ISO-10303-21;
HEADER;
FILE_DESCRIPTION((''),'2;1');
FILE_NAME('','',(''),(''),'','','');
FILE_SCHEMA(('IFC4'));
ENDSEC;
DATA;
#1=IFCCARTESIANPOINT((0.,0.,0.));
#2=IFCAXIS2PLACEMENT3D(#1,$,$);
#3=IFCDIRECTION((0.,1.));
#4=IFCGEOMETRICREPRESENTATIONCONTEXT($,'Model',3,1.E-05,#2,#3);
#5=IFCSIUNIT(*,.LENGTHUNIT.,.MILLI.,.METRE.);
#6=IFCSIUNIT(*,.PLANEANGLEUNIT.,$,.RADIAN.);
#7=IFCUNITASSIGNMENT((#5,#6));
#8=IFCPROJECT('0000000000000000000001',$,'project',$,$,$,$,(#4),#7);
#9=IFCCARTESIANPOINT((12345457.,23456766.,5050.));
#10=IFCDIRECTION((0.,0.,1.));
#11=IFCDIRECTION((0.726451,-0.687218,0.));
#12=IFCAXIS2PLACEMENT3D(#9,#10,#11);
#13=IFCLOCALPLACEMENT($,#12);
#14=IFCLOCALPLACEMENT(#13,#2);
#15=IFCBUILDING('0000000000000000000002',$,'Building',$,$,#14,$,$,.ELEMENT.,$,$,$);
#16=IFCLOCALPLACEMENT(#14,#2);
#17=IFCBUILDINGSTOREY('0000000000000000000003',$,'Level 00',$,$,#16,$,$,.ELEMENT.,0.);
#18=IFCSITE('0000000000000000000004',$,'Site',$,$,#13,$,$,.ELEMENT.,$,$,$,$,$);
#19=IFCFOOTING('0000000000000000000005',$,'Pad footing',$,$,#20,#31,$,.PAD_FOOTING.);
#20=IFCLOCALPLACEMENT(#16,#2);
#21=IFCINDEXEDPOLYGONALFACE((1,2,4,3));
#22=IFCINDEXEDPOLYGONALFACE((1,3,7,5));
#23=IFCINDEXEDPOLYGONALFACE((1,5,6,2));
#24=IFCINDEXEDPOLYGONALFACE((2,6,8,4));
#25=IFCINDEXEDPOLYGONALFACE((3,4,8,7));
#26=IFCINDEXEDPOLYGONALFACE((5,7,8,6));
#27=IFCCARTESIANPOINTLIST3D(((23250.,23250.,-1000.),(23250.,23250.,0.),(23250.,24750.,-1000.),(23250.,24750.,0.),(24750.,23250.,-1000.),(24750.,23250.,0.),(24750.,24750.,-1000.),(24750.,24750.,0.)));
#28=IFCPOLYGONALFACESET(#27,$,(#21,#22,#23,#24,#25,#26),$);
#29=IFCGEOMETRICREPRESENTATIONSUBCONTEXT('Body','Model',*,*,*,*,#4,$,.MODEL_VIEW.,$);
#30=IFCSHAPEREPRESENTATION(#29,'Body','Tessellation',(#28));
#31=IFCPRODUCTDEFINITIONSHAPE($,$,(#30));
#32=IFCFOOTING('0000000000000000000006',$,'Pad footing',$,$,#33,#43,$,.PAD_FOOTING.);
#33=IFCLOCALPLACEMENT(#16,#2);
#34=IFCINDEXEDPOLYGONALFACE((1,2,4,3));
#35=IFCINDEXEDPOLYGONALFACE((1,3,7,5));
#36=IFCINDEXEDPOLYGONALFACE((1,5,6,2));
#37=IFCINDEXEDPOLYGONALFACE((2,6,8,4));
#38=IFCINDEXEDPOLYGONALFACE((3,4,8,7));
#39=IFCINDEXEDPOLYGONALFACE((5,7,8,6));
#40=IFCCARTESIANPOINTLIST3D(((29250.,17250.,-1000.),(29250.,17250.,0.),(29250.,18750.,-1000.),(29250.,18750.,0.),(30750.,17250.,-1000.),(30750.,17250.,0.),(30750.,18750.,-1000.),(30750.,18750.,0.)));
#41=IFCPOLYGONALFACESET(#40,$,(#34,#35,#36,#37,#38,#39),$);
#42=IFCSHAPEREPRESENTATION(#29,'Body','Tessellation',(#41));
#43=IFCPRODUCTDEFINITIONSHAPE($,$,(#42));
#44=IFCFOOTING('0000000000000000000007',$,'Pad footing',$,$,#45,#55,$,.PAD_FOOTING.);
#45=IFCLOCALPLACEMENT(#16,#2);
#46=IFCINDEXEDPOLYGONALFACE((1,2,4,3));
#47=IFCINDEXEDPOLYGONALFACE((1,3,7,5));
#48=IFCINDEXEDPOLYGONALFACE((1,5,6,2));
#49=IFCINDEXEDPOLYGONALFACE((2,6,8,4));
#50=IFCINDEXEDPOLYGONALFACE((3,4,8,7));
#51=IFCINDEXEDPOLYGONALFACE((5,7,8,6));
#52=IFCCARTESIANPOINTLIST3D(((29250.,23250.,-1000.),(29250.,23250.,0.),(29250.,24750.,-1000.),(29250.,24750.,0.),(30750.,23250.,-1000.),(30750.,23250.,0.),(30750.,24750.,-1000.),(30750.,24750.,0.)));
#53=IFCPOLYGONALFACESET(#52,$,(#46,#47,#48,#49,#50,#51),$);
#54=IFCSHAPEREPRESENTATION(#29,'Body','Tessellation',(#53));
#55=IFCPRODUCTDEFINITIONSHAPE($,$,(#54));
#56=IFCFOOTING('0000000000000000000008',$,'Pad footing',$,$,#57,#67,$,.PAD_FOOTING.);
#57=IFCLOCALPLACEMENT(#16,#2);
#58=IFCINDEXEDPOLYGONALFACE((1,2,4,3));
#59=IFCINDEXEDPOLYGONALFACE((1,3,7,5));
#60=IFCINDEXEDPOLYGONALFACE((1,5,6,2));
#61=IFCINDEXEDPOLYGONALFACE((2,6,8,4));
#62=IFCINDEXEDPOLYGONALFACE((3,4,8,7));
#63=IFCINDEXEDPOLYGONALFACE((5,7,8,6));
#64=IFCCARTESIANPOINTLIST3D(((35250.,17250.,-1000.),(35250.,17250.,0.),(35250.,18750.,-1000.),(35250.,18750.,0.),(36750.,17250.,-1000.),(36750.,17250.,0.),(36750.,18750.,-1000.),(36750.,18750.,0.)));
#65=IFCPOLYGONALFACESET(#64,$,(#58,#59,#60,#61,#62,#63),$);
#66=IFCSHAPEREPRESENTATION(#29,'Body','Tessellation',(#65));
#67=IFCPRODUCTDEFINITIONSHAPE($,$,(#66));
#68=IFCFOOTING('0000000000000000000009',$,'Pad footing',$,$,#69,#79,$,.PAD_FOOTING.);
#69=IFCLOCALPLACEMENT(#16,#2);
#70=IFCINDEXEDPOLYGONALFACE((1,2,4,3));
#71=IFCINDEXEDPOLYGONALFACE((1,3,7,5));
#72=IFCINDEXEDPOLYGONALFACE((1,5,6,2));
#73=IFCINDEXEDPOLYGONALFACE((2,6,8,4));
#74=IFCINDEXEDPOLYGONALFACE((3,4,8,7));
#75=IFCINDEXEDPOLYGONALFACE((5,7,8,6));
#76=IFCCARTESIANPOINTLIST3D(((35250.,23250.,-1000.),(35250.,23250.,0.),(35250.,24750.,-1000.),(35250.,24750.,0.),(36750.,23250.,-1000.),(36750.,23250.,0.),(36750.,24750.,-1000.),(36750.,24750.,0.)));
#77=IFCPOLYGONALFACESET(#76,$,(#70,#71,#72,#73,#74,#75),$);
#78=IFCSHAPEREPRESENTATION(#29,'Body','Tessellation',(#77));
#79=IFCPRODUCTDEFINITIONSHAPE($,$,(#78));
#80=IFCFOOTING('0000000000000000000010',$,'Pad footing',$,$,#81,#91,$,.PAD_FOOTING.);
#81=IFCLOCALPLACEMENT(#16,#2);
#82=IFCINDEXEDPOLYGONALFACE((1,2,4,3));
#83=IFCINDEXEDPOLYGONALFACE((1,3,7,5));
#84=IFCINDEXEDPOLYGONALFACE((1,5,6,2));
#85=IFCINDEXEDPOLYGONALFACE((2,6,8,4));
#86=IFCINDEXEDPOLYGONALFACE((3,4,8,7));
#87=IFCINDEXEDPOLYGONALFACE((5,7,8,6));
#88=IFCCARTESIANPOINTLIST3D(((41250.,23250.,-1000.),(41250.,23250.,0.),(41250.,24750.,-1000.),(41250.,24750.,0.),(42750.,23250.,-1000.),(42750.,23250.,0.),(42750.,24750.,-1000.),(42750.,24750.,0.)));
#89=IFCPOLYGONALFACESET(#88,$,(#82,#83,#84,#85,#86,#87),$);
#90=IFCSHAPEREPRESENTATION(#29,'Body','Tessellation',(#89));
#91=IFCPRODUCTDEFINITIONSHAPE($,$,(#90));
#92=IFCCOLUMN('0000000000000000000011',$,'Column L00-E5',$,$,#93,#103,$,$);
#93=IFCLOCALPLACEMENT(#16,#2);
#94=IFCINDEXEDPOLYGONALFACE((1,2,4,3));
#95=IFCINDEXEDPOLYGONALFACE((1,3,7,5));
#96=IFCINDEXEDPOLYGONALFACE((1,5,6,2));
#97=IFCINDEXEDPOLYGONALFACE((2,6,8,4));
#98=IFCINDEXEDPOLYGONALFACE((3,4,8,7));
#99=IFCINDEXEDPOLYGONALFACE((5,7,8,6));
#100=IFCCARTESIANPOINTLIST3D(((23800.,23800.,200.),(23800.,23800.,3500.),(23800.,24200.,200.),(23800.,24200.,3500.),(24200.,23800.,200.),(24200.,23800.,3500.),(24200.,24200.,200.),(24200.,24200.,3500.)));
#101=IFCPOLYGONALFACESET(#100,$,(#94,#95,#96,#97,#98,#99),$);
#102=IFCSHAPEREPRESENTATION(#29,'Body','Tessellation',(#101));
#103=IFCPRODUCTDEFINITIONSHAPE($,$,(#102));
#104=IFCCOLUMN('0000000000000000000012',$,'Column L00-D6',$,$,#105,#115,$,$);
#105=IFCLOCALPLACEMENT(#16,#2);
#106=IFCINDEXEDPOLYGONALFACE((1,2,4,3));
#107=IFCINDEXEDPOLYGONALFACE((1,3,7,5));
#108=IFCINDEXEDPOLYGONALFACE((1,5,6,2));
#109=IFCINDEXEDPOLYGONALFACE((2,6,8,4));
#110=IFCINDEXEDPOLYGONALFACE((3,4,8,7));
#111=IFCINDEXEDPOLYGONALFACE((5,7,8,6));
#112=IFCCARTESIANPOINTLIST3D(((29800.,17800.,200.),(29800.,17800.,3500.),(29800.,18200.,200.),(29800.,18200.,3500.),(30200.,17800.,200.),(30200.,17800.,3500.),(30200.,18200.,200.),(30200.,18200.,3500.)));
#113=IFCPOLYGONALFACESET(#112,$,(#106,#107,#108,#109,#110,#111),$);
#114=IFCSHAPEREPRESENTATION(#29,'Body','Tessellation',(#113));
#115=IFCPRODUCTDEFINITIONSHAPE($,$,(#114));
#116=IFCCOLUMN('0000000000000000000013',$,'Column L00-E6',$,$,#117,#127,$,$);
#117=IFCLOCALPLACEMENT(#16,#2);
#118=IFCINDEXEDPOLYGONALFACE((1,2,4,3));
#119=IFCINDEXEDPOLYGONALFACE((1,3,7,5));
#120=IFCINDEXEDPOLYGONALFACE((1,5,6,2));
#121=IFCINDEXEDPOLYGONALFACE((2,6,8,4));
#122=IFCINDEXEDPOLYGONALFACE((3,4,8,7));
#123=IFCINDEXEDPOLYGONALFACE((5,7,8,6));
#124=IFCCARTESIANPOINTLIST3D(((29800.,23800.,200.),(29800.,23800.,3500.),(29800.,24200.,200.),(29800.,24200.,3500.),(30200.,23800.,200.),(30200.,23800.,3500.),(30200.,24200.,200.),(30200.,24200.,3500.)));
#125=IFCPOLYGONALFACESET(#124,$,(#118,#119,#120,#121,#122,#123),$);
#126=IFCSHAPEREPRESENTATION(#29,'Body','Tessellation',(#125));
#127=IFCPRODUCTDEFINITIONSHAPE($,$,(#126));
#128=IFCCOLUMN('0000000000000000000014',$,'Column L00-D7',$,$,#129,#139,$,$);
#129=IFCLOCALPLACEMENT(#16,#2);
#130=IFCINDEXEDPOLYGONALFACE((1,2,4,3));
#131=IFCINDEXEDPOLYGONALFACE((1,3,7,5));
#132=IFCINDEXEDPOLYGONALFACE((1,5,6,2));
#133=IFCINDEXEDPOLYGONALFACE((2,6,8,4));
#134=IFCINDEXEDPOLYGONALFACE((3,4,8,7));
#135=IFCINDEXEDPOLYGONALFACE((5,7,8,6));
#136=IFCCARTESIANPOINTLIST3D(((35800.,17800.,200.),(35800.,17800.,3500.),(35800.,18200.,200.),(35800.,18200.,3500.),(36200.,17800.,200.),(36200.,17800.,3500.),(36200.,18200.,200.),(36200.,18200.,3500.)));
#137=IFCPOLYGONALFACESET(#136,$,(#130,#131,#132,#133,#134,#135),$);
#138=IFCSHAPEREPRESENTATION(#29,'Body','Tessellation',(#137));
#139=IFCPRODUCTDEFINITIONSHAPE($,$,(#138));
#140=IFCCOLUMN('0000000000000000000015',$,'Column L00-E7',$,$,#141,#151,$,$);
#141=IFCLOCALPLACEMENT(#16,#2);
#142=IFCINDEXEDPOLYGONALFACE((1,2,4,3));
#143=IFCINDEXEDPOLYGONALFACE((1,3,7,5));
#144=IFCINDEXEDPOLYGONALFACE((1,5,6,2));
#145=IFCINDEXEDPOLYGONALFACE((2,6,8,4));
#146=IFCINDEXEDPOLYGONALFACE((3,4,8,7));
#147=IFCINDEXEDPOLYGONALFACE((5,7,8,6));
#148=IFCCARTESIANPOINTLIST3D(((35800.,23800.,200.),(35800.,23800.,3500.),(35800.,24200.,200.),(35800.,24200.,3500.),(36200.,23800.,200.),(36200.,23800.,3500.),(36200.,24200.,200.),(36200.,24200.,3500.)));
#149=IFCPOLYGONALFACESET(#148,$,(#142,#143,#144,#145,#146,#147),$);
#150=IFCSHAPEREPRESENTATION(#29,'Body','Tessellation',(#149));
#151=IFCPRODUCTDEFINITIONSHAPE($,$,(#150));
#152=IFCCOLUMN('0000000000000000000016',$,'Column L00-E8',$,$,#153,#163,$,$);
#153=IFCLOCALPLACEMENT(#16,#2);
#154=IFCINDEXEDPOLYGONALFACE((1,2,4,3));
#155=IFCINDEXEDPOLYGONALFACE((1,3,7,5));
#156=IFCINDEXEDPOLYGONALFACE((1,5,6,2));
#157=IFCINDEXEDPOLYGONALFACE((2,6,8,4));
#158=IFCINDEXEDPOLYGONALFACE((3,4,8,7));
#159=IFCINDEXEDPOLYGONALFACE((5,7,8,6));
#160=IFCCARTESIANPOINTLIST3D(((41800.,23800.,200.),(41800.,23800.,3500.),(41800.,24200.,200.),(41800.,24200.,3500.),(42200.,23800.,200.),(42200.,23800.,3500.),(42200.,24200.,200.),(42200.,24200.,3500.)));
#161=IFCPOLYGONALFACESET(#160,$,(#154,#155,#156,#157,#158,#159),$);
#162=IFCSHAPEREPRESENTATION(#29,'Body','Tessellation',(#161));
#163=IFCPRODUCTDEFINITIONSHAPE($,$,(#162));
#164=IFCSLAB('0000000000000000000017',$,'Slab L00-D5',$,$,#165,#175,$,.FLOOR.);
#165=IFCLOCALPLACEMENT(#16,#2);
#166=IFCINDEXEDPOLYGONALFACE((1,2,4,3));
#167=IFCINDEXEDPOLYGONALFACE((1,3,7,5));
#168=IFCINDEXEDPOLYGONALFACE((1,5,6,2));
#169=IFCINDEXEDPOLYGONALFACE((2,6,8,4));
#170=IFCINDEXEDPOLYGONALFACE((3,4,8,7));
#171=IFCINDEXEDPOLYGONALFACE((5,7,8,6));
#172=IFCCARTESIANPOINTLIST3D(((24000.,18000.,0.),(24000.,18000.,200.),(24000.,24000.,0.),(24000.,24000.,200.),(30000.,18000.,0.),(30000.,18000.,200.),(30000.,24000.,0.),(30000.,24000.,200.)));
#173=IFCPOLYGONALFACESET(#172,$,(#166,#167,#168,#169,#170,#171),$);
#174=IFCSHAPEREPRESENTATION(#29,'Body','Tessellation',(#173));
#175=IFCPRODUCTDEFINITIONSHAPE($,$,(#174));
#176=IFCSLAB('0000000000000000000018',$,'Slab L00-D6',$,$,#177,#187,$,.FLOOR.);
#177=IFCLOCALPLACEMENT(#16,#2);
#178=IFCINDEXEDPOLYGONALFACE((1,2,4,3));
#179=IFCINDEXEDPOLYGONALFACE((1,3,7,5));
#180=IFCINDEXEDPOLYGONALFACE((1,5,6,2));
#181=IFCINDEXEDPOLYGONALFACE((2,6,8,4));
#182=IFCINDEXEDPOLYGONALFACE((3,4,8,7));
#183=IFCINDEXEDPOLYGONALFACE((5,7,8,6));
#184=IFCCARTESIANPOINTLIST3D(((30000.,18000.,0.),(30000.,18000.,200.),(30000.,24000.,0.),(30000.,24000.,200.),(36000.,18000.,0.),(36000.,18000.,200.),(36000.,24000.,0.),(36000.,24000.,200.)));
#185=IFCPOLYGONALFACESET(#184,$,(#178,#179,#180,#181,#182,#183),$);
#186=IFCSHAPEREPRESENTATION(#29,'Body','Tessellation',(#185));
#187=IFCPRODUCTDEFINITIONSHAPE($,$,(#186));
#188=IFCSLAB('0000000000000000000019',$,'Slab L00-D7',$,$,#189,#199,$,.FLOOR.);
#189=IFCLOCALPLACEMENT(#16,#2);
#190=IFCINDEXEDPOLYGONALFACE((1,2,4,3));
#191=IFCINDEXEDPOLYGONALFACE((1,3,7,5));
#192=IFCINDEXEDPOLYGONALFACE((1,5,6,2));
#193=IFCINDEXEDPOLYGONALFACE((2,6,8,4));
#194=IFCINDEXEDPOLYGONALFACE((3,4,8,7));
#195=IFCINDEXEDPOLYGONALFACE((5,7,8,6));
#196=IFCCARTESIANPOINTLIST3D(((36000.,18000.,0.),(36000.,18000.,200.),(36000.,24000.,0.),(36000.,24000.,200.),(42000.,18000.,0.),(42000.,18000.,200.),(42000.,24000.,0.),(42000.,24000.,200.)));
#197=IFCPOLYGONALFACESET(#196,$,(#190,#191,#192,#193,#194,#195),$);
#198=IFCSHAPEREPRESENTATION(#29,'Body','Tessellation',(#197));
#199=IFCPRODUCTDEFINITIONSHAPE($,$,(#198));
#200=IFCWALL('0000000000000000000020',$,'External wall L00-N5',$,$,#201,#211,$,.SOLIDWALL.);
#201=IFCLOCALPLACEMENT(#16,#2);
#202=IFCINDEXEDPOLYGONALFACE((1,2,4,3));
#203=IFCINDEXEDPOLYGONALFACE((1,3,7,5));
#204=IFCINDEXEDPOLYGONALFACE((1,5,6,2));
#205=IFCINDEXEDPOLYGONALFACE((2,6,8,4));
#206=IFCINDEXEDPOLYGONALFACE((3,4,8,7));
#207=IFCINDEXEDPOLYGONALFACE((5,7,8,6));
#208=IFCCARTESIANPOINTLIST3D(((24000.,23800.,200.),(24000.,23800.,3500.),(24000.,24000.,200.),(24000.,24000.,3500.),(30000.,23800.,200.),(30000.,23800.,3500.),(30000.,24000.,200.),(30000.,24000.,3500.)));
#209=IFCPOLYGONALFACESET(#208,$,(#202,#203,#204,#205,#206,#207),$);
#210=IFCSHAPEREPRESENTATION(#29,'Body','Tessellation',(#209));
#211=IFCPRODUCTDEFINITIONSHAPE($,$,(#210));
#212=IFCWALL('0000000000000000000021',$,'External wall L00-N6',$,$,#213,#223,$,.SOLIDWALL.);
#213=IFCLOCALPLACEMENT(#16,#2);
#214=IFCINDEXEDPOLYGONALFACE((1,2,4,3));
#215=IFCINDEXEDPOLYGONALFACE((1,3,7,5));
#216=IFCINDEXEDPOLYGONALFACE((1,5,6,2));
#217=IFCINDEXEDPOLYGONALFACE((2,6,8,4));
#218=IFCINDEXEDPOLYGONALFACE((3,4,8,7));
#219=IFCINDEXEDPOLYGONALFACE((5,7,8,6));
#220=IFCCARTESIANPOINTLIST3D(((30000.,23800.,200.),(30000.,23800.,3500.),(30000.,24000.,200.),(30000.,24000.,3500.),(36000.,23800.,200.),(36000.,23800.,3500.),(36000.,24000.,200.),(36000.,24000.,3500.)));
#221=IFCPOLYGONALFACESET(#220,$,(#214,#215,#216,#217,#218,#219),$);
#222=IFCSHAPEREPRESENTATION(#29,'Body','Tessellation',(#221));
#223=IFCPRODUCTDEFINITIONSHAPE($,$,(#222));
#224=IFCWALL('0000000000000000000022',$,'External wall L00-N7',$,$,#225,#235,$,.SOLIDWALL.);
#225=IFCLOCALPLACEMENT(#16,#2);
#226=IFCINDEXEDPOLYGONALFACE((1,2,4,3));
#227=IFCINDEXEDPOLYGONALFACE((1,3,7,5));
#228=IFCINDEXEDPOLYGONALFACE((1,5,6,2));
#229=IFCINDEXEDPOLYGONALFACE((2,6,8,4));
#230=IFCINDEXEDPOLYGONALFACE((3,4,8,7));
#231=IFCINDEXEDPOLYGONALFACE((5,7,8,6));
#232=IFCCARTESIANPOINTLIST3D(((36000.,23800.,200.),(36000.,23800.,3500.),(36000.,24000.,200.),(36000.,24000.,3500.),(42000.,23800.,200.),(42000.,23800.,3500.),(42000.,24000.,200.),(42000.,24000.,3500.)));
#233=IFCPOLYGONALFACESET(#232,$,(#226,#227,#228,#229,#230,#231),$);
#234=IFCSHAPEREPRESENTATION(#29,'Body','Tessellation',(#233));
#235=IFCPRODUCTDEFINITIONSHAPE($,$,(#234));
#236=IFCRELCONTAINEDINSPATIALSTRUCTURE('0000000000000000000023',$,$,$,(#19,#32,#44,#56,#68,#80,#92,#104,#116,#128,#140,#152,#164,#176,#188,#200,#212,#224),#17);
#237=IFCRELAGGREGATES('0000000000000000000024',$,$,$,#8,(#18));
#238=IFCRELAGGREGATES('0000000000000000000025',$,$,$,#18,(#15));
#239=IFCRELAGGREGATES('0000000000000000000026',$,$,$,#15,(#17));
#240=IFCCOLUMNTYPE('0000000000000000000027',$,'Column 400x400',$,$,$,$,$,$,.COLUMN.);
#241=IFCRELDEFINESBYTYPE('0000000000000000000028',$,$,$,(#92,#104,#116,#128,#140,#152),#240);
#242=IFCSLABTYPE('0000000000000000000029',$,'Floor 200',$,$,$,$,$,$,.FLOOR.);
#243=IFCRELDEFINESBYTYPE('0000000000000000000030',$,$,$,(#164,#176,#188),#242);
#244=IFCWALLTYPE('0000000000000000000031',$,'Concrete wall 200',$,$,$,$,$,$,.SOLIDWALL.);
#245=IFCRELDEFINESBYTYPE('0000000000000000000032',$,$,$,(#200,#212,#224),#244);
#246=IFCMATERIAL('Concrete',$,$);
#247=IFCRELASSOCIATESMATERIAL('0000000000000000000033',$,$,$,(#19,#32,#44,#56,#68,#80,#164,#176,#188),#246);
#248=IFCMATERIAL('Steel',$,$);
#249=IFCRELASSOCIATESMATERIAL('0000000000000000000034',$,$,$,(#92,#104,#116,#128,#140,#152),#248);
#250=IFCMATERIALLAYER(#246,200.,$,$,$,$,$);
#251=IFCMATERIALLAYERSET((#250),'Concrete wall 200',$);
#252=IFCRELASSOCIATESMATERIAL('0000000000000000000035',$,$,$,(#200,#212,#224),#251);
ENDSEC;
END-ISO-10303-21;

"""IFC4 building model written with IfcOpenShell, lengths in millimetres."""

from ifc_helpers import new_model, si_unit, direction, frame, origin, place, context, subcontext, project, spatial, rectangle, extrude, material, layer, layer_set, layer_usage, type_object, element, save


model = new_model("IFC4")

# Units and contexts
model_context = context("Model", 3, precision=1e-05, world=origin(), true_north=direction((0.0, 1.0)))
body_context = subcontext(model_context, "Body", "Model", "MODEL_VIEW")
ifc_project = project(units=[si_unit("LENGTHUNIT", "METRE", prefix="MILLI"), si_unit("PLANEANGLEUNIT", "RADIAN")], contexts=[model_context])

# Site, building, storey
site_placement = place(None, frame((12345457.0, 23456766.0, 5050.0), z_axis=(0.0, 0.0, 1.0), x_axis=(0.726451, -0.687218, 0.0)))
site = spatial("IfcSite", under=ifc_project, at=site_placement, Name="Site", CompositionType="ELEMENT")
building_placement = place(site_placement, origin())
building = spatial("IfcBuilding", under=site, at=building_placement, Name="Building", CompositionType="ELEMENT")
storey_placement = place(building_placement, origin())
storey = spatial("IfcBuildingStorey", under=building, at=storey_placement, Name="Level 00", CompositionType="ELEMENT", Elevation=0.0)

# Footings
ifc_material_1 = material(Name="Concrete")
for number, where, name in (
    (1, (23250.0, 23250.0, -1000.0), "Pad footing"),
    (2, (29250.0, 17250.0, -1000.0), "Pad footing"),
    (3, (29250.0, 23250.0, -1000.0), "Pad footing"),
    (4, (35250.0, 17250.0, -1000.0), "Pad footing"),
    (5, (35250.0, 23250.0, -1000.0), "Pad footing"),
    (6, (41250.0, 23250.0, -1000.0), "Pad footing"),
):
    element("IfcFooting", number, at=place(storey_placement, frame(where)), inside=storey, material=ifc_material_1, Name=name, PredefinedType="PAD_FOOTING", context=body_context, shape_type="SweptSolid", body=[
        extrude(rectangle(XDim=1500.0, YDim=1500.0), frame((750.0, 750.0, 0.0)), (0.0, 0.0, 1.0), 1000.0),
    ])

# Columns
ifc_material_2 = material(Name="Steel")
column_type = type_object("IfcColumnType", Name="Column 400x400", PredefinedType="COLUMN")
for number, where, name in (
    (7, (23800.0, 23800.0, 200.0), "Column L00-E5"),
    (8, (29800.0, 17800.0, 200.0), "Column L00-D6"),
    (9, (29800.0, 23800.0, 200.0), "Column L00-E6"),
    (10, (35800.0, 17800.0, 200.0), "Column L00-D7"),
    (11, (35800.0, 23800.0, 200.0), "Column L00-E7"),
    (12, (41800.0, 23800.0, 200.0), "Column L00-E8"),
):
    element("IfcColumn", number, at=place(storey_placement, frame(where)), inside=storey, type_object=column_type, material=ifc_material_2, Name=name, context=body_context, shape_type="SweptSolid", body=[
        extrude(rectangle(XDim=400.0, YDim=400.0), frame((200.0, 200.0, 0.0)), (0.0, 0.0, 1.0), 3300.0),
    ])

# Slabs
slab_type = type_object("IfcSlabType", Name="Floor 200", PredefinedType="FLOOR")
for number, where, name in (
    (13, (24000.0, 18000.0, 0.0), "Slab L00-D5"),
    (14, (30000.0, 18000.0, 0.0), "Slab L00-D6"),
    (15, (36000.0, 18000.0, 0.0), "Slab L00-D7"),
):
    element("IfcSlab", number, at=place(storey_placement, frame(where)), inside=storey, type_object=slab_type, material=ifc_material_1, Name=name, PredefinedType="FLOOR", context=body_context, shape_type="SweptSolid", body=[
        extrude(rectangle(XDim=6000.0, YDim=6000.0), frame((3000.0, 3000.0, 0.0)), (0.0, 0.0, 1.0), 200.0),
    ])

# Walls
ifc_layer_1 = layer(ifc_material_1, 200.0)
ifc_layer_set_1 = layer_set([ifc_layer_1], Name="Concrete wall 200")
ifc_layer_usage_1 = layer_usage(ifc_layer_set_1, "AXIS2", "POSITIVE", 0.0)
wall_type_1 = type_object("IfcWallType", Name="Concrete wall 200", PredefinedType="SOLIDWALL")
for number, where, name in (
    (16, (24000.0, 23800.0, 200.0), "External wall L00-N5"),
    (17, (30000.0, 23800.0, 200.0), "External wall L00-N6"),
    (18, (36000.0, 23800.0, 200.0), "External wall L00-N7"),
):
    element("IfcWall", number, at=place(storey_placement, frame(where)), inside=storey, type_object=wall_type_1, material=ifc_layer_usage_1, Name=name, PredefinedType="SOLIDWALL", context=body_context, shape_type="SweptSolid", body=[
        extrude(rectangle(XDim=6000.0, YDim=200.0), frame((3000.0, 100.0, 0.0)), (0.0, 0.0, 1.0), 3300.0),
    ])

save(model, "model.ifc")
